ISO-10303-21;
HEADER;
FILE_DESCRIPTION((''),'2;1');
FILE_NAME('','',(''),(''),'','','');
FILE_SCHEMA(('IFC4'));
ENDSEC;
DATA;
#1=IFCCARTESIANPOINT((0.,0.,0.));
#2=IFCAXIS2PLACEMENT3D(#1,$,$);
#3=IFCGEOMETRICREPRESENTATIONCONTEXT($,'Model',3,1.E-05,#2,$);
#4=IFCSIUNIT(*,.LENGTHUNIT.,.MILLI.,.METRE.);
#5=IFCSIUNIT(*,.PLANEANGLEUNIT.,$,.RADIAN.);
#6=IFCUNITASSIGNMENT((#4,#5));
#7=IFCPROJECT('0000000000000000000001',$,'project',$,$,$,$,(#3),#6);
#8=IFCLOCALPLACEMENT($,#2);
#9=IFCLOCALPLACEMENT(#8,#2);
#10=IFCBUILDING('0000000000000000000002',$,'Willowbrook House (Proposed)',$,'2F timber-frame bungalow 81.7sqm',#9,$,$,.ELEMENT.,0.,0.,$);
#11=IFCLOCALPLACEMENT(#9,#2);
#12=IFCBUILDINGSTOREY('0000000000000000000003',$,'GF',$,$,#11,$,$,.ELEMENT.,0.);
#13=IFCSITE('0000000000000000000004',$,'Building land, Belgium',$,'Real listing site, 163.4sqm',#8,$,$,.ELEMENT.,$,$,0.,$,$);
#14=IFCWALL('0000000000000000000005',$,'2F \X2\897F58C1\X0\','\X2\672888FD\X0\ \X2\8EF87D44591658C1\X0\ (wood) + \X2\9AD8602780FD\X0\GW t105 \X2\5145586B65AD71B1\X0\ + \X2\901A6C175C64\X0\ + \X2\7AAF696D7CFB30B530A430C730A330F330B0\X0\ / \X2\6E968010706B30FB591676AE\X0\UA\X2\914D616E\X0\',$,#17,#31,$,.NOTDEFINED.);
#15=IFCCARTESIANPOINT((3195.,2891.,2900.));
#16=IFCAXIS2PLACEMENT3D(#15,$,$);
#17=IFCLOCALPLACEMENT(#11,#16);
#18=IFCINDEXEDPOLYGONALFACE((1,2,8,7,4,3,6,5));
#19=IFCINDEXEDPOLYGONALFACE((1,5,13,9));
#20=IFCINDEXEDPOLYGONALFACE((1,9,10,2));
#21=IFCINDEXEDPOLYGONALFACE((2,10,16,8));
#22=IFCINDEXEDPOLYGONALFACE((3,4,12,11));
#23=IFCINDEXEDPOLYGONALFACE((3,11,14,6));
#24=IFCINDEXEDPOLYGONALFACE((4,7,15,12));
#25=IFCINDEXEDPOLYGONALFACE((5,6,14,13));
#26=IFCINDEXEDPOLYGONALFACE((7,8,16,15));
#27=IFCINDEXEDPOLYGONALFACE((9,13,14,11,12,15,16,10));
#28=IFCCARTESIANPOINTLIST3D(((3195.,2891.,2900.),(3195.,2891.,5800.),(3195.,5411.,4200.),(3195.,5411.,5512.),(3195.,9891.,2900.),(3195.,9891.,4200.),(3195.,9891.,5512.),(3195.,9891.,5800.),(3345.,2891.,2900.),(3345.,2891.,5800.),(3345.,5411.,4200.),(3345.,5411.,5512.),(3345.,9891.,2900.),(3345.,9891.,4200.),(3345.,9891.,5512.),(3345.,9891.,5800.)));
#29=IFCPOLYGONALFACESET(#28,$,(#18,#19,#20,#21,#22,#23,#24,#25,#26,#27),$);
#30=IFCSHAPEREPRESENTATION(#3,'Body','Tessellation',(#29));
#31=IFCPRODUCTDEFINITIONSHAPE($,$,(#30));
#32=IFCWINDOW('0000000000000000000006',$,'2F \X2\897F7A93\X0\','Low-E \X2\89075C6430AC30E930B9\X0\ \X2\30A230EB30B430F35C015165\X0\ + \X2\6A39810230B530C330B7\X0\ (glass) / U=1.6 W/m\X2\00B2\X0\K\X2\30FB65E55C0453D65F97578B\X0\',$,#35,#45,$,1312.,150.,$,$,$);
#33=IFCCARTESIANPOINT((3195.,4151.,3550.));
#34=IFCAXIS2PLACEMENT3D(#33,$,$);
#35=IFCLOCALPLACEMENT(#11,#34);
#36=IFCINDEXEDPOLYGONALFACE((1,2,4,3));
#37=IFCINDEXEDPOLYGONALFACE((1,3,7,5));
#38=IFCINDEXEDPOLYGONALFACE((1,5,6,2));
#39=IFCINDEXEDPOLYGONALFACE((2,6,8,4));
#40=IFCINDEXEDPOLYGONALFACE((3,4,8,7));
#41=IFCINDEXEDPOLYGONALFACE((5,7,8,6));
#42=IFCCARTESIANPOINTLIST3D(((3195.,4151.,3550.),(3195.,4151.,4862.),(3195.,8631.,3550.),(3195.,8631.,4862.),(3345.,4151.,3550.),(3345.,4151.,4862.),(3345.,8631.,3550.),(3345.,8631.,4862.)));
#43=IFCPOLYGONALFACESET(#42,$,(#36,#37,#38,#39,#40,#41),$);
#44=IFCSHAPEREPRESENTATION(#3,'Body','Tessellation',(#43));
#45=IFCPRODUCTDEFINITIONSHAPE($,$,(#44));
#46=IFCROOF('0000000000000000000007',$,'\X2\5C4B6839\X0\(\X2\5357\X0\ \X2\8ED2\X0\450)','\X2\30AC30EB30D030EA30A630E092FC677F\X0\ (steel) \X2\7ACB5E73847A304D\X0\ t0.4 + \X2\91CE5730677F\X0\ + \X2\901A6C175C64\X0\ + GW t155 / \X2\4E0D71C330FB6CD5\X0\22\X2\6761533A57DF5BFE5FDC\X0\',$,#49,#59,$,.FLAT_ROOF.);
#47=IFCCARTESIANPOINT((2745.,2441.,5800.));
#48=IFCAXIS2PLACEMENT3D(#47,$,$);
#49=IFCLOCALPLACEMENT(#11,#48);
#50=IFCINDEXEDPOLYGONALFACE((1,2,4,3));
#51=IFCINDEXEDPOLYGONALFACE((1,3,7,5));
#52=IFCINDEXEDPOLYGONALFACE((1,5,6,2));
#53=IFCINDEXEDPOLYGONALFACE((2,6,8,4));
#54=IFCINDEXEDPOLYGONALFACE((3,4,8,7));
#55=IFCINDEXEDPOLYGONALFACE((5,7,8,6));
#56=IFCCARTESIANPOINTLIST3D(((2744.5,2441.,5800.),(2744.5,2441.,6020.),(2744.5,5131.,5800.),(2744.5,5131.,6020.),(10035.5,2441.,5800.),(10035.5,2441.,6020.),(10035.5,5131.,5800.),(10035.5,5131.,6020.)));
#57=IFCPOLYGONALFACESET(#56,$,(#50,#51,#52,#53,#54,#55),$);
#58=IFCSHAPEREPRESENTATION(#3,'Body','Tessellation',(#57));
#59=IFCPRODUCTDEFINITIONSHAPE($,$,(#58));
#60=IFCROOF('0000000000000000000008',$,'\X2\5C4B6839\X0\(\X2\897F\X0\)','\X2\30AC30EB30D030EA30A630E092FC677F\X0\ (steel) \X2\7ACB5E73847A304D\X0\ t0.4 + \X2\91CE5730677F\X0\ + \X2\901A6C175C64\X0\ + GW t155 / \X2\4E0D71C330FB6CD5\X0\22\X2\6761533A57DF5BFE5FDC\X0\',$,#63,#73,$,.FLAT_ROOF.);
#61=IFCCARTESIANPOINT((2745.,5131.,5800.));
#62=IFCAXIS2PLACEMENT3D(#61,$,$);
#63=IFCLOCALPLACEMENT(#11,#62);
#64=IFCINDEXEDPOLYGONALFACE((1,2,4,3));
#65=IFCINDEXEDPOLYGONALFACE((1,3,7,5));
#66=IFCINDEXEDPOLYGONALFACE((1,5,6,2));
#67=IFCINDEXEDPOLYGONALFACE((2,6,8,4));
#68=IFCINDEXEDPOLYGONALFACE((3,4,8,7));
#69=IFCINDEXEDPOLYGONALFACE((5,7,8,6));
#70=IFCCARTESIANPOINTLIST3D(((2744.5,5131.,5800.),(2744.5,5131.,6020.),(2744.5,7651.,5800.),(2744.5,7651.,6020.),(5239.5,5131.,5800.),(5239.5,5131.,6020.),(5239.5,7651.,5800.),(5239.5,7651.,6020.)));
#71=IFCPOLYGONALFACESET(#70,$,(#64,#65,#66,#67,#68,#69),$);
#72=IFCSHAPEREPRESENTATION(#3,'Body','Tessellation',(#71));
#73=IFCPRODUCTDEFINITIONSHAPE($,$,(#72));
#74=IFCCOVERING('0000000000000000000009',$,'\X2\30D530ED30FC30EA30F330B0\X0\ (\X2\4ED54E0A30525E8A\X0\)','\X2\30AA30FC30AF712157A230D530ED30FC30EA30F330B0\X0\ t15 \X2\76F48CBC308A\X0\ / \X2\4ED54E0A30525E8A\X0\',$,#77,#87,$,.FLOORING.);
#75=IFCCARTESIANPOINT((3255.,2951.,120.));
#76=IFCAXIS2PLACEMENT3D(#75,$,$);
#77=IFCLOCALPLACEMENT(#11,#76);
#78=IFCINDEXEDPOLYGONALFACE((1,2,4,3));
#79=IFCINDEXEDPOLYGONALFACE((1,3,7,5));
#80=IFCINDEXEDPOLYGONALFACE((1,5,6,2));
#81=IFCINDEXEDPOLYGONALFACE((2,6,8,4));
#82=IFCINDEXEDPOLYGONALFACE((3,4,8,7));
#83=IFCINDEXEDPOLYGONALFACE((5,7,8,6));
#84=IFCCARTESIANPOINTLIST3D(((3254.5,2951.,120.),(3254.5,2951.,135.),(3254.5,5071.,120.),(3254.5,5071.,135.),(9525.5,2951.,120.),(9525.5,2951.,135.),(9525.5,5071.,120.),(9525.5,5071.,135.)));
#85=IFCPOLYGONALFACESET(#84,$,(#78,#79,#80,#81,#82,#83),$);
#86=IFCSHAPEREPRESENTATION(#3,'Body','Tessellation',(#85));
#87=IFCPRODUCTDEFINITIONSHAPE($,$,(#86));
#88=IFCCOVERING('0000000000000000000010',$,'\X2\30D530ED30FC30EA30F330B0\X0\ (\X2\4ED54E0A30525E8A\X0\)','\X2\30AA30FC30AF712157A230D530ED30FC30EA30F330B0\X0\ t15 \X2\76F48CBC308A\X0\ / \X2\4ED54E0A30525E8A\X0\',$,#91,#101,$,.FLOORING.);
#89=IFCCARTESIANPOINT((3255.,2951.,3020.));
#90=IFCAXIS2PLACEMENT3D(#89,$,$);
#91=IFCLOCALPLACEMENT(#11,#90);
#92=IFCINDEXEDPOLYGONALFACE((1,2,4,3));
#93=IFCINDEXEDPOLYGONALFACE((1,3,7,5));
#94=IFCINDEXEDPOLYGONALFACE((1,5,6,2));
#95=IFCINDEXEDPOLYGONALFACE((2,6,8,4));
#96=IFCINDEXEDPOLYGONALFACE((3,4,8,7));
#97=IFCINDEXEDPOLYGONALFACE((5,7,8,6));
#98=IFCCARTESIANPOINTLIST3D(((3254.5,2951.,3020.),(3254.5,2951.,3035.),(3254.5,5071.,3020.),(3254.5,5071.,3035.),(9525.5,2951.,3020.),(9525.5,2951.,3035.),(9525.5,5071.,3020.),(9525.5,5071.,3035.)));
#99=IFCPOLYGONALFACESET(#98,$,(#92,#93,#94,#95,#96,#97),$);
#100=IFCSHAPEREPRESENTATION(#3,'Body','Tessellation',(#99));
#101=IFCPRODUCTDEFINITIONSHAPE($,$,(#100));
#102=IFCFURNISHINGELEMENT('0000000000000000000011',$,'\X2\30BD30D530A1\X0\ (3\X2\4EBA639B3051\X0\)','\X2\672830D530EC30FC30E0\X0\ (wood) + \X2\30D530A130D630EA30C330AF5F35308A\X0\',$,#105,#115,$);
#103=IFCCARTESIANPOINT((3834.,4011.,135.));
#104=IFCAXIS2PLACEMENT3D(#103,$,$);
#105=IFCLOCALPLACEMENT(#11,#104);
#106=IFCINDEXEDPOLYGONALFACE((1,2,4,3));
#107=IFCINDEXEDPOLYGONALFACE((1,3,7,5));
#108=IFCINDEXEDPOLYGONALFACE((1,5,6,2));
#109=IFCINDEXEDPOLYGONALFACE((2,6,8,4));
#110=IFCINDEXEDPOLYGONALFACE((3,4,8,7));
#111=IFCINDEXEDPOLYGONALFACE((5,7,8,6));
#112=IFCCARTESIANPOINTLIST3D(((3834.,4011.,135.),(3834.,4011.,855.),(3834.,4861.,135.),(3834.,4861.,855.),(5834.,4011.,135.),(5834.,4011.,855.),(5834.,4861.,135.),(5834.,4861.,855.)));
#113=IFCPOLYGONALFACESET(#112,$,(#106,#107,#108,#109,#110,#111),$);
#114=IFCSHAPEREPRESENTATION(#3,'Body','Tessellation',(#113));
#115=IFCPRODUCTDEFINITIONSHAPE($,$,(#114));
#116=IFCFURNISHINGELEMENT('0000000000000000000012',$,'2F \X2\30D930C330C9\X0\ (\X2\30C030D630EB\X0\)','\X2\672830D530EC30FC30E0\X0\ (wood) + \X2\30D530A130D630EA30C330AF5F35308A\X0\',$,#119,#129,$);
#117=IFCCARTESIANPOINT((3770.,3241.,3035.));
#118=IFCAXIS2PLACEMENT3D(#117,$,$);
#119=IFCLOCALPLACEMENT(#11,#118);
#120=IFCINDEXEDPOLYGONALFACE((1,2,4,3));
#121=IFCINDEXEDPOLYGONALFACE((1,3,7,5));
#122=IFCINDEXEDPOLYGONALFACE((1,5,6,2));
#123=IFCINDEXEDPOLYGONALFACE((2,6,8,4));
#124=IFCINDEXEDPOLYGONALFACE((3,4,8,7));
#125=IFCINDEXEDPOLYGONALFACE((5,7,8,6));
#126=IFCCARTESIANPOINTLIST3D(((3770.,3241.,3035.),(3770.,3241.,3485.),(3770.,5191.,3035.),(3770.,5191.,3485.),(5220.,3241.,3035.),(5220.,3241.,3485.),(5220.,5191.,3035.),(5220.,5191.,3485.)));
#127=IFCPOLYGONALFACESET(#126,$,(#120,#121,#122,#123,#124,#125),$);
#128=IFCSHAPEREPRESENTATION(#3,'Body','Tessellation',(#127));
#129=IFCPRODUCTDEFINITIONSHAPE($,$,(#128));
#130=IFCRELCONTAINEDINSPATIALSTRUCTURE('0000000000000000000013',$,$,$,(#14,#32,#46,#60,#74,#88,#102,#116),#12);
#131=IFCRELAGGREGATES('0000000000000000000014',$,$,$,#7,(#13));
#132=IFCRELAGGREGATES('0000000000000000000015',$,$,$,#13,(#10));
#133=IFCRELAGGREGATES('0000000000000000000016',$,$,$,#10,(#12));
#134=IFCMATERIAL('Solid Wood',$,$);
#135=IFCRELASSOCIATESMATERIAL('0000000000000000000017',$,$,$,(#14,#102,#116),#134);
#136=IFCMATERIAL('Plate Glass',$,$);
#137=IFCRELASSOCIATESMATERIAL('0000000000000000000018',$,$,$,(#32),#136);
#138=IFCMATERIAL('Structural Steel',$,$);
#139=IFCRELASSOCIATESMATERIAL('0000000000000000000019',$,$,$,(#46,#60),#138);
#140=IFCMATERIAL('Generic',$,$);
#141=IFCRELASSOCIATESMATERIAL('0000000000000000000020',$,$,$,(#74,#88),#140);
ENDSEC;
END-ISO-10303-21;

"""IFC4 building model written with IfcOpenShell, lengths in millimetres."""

from ifc_helpers import new_model, si_unit, frame, frame_2d, origin, place, context, project, spatial, rectangle, extrude, material, element, fill, save


model = new_model("IFC4")

# Units and contexts
model_context = context("Model", 3, precision=1e-05, world=origin())
ifc_project = project(units=[si_unit("LENGTHUNIT", "METRE", prefix="MILLI"), si_unit("PLANEANGLEUNIT", "RADIAN")], contexts=[model_context])

# Site, building, storey
site_placement = place(None, origin())
site = spatial("IfcSite", under=ifc_project, at=site_placement, Name="Building land, Belgium", ObjectType="Real listing site, 163.4sqm", CompositionType="ELEMENT", RefElevation=0.0)
building_placement = place(site_placement, origin())
building = spatial("IfcBuilding", under=site, at=building_placement, Name="Willowbrook House (Proposed)", ObjectType="2F timber-frame bungalow 81.7sqm", CompositionType="ELEMENT", ElevationOfRefHeight=0.0, ElevationOfTerrain=0.0)
storey_placement = place(building_placement, origin())
storey = spatial("IfcBuildingStorey", under=building, at=storey_placement, Name="GF", CompositionType="ELEMENT", Elevation=0.0)

# Shared definitions
ifc_material_1 = material(Name="Solid Wood")

# Shared definitions
ifc_material_2 = material(Name="Plate Glass")

# Wall, opening, window
wall_1_placement = place(storey_placement, frame((3195.0, 2891.0, 2900.0)))
wall_1 = element("IfcWall", 1, at=wall_1_placement, inside=storey, material=ifc_material_1, Name="2F 西壁", Description="木製 軸組外壁 (wood) + 高性能GW t105 充填断熱 + 通気層 + 窯業系サイディング / 準耐火・外皮UA配慮", PredefinedType="NOTDEFINED", context=model_context, shape_type="SweptSolid", body=[
    extrude(rectangle(XDim=150.0, YDim=7000.0, at=frame_2d((75.0, 3500.0))), frame((3195.0, 2891.0, 2900.0)), (0.0, 0.0, 1.0), 2900.0),
])
opening_1_placement = place(storey_placement, frame((3195.0, 4151.0, 3550.0)))
opening_1 = element("IfcOpeningElement", 2, at=opening_1_placement, cuts=wall_1, PredefinedType="NOTDEFINED", context=model_context, shape_type="SweptSolid", body=[
    extrude(rectangle(XDim=150.0, YDim=4480.0, at=frame_2d((75.0, 2240.0))), frame((3195.0, 4151.0, 3550.0)), (0.0, 0.0, 1.0), 1312.0),
])
window_1_placement = place(storey_placement, frame((3195.0, 4151.0, 3550.0)))
window_1 = element("IfcWindow", 3, at=window_1_placement, inside=storey, material=ifc_material_2, Name="2F 西窓", Description="Low-E 複層ガラス アルゴン封入 + 樹脂サッシ (glass) / U=1.6 W/m²K・日射取得型", OverallHeight=1312.0, OverallWidth=150.0, context=model_context, shape_type="SweptSolid", body=[
    extrude(rectangle(XDim=150.0, YDim=4480.0, at=frame_2d((75.0, 2240.0))), frame((3195.0, 4151.0, 3550.0)), (0.0, 0.0, 1.0), 1312.0),
])
fill(opening_1, window_1)

# Roofs
ifc_material_3 = material(Name="Structural Steel")
roof_1_placement = place(storey_placement, frame((2745.0, 2441.0, 5800.0)))
element("IfcRoof", 4, at=roof_1_placement, inside=storey, material=ifc_material_3, Name="屋根(南 軒450)", Description="ガルバリウム鋼板 (steel) 立平葺き t0.4 + 野地板 + 通気層 + GW t155 / 不燃・法22条区域対応", PredefinedType="FLAT_ROOF", context=model_context, shape_type="SweptSolid", body=[
    extrude(rectangle(XDim=7291.0, YDim=2690.0, at=frame_2d((3645.0, 1345.0))), frame((2745.0, 2441.0, 5800.0)), (0.0, 0.0, 1.0), 220.0),
])
roof_2_placement = place(storey_placement, frame((2745.0, 5131.0, 5800.0)))
element("IfcRoof", 5, at=roof_2_placement, inside=storey, material=ifc_material_3, Name="屋根(西)", Description="ガルバリウム鋼板 (steel) 立平葺き t0.4 + 野地板 + 通気層 + GW t155 / 不燃・法22条区域対応", PredefinedType="FLAT_ROOF", context=model_context, shape_type="SweptSolid", body=[
    extrude(rectangle(XDim=2495.0, YDim=2520.0, at=frame_2d((1247.0, 1260.0))), frame((2745.0, 5131.0, 5800.0)), (0.0, 0.0, 1.0), 220.0),
])

# Coverings
ifc_material_4 = material(Name="Generic")
covering_1_placement = place(storey_placement, frame((3255.0, 2951.0, 120.0)))
element("IfcCovering", 6, at=covering_1_placement, inside=storey, material=ifc_material_4, Name="フローリング (仕上げ床)", Description="オーク無垢フローリング t15 直貼り / 仕上げ床", PredefinedType="FLOORING", context=model_context, shape_type="SweptSolid", body=[
    extrude(rectangle(XDim=6271.0, YDim=2120.0, at=frame_2d((3135.0, 1060.0))), frame((3255.0, 2951.0, 120.0)), (0.0, 0.0, 1.0), 15.0),
])
covering_2_placement = place(storey_placement, frame((3255.0, 2951.0, 3020.0)))
element("IfcCovering", 7, at=covering_2_placement, inside=storey, material=ifc_material_4, Name="フローリング (仕上げ床)", Description="オーク無垢フローリング t15 直貼り / 仕上げ床", PredefinedType="FLOORING", context=model_context, shape_type="SweptSolid", body=[
    extrude(rectangle(XDim=6271.0, YDim=2120.0, at=frame_2d((3135.0, 1060.0))), frame((3255.0, 2951.0, 3020.0)), (0.0, 0.0, 1.0), 15.0),
])

# Furnishing elements
furnishing_1_placement = place(storey_placement, frame((3834.0, 4011.0, 135.0)))
element("IfcFurnishingElement", 8, at=furnishing_1_placement, inside=storey, material=ifc_material_1, Name="ソファ (3人掛け)", Description="木フレーム (wood) + ファブリック張り", context=model_context, shape_type="SweptSolid", body=[
    extrude(rectangle(XDim=2000.0, YDim=850.0, at=frame_2d((1000.0, 425.0))), frame((3834.0, 4011.0, 135.0)), (0.0, 0.0, 1.0), 720.0),
])
furnishing_2_placement = place(storey_placement, frame((3770.0, 3241.0, 3035.0)))
element("IfcFurnishingElement", 9, at=furnishing_2_placement, inside=storey, material=ifc_material_1, Name="2F ベッド (ダブル)", Description="木フレーム (wood) + ファブリック張り", context=model_context, shape_type="SweptSolid", body=[
    extrude(rectangle(XDim=1450.0, YDim=1950.0, at=frame_2d((725.0, 975.0))), frame((3770.0, 3241.0, 3035.0)), (0.0, 0.0, 1.0), 450.0),
])

save(model, "model.ifc")
